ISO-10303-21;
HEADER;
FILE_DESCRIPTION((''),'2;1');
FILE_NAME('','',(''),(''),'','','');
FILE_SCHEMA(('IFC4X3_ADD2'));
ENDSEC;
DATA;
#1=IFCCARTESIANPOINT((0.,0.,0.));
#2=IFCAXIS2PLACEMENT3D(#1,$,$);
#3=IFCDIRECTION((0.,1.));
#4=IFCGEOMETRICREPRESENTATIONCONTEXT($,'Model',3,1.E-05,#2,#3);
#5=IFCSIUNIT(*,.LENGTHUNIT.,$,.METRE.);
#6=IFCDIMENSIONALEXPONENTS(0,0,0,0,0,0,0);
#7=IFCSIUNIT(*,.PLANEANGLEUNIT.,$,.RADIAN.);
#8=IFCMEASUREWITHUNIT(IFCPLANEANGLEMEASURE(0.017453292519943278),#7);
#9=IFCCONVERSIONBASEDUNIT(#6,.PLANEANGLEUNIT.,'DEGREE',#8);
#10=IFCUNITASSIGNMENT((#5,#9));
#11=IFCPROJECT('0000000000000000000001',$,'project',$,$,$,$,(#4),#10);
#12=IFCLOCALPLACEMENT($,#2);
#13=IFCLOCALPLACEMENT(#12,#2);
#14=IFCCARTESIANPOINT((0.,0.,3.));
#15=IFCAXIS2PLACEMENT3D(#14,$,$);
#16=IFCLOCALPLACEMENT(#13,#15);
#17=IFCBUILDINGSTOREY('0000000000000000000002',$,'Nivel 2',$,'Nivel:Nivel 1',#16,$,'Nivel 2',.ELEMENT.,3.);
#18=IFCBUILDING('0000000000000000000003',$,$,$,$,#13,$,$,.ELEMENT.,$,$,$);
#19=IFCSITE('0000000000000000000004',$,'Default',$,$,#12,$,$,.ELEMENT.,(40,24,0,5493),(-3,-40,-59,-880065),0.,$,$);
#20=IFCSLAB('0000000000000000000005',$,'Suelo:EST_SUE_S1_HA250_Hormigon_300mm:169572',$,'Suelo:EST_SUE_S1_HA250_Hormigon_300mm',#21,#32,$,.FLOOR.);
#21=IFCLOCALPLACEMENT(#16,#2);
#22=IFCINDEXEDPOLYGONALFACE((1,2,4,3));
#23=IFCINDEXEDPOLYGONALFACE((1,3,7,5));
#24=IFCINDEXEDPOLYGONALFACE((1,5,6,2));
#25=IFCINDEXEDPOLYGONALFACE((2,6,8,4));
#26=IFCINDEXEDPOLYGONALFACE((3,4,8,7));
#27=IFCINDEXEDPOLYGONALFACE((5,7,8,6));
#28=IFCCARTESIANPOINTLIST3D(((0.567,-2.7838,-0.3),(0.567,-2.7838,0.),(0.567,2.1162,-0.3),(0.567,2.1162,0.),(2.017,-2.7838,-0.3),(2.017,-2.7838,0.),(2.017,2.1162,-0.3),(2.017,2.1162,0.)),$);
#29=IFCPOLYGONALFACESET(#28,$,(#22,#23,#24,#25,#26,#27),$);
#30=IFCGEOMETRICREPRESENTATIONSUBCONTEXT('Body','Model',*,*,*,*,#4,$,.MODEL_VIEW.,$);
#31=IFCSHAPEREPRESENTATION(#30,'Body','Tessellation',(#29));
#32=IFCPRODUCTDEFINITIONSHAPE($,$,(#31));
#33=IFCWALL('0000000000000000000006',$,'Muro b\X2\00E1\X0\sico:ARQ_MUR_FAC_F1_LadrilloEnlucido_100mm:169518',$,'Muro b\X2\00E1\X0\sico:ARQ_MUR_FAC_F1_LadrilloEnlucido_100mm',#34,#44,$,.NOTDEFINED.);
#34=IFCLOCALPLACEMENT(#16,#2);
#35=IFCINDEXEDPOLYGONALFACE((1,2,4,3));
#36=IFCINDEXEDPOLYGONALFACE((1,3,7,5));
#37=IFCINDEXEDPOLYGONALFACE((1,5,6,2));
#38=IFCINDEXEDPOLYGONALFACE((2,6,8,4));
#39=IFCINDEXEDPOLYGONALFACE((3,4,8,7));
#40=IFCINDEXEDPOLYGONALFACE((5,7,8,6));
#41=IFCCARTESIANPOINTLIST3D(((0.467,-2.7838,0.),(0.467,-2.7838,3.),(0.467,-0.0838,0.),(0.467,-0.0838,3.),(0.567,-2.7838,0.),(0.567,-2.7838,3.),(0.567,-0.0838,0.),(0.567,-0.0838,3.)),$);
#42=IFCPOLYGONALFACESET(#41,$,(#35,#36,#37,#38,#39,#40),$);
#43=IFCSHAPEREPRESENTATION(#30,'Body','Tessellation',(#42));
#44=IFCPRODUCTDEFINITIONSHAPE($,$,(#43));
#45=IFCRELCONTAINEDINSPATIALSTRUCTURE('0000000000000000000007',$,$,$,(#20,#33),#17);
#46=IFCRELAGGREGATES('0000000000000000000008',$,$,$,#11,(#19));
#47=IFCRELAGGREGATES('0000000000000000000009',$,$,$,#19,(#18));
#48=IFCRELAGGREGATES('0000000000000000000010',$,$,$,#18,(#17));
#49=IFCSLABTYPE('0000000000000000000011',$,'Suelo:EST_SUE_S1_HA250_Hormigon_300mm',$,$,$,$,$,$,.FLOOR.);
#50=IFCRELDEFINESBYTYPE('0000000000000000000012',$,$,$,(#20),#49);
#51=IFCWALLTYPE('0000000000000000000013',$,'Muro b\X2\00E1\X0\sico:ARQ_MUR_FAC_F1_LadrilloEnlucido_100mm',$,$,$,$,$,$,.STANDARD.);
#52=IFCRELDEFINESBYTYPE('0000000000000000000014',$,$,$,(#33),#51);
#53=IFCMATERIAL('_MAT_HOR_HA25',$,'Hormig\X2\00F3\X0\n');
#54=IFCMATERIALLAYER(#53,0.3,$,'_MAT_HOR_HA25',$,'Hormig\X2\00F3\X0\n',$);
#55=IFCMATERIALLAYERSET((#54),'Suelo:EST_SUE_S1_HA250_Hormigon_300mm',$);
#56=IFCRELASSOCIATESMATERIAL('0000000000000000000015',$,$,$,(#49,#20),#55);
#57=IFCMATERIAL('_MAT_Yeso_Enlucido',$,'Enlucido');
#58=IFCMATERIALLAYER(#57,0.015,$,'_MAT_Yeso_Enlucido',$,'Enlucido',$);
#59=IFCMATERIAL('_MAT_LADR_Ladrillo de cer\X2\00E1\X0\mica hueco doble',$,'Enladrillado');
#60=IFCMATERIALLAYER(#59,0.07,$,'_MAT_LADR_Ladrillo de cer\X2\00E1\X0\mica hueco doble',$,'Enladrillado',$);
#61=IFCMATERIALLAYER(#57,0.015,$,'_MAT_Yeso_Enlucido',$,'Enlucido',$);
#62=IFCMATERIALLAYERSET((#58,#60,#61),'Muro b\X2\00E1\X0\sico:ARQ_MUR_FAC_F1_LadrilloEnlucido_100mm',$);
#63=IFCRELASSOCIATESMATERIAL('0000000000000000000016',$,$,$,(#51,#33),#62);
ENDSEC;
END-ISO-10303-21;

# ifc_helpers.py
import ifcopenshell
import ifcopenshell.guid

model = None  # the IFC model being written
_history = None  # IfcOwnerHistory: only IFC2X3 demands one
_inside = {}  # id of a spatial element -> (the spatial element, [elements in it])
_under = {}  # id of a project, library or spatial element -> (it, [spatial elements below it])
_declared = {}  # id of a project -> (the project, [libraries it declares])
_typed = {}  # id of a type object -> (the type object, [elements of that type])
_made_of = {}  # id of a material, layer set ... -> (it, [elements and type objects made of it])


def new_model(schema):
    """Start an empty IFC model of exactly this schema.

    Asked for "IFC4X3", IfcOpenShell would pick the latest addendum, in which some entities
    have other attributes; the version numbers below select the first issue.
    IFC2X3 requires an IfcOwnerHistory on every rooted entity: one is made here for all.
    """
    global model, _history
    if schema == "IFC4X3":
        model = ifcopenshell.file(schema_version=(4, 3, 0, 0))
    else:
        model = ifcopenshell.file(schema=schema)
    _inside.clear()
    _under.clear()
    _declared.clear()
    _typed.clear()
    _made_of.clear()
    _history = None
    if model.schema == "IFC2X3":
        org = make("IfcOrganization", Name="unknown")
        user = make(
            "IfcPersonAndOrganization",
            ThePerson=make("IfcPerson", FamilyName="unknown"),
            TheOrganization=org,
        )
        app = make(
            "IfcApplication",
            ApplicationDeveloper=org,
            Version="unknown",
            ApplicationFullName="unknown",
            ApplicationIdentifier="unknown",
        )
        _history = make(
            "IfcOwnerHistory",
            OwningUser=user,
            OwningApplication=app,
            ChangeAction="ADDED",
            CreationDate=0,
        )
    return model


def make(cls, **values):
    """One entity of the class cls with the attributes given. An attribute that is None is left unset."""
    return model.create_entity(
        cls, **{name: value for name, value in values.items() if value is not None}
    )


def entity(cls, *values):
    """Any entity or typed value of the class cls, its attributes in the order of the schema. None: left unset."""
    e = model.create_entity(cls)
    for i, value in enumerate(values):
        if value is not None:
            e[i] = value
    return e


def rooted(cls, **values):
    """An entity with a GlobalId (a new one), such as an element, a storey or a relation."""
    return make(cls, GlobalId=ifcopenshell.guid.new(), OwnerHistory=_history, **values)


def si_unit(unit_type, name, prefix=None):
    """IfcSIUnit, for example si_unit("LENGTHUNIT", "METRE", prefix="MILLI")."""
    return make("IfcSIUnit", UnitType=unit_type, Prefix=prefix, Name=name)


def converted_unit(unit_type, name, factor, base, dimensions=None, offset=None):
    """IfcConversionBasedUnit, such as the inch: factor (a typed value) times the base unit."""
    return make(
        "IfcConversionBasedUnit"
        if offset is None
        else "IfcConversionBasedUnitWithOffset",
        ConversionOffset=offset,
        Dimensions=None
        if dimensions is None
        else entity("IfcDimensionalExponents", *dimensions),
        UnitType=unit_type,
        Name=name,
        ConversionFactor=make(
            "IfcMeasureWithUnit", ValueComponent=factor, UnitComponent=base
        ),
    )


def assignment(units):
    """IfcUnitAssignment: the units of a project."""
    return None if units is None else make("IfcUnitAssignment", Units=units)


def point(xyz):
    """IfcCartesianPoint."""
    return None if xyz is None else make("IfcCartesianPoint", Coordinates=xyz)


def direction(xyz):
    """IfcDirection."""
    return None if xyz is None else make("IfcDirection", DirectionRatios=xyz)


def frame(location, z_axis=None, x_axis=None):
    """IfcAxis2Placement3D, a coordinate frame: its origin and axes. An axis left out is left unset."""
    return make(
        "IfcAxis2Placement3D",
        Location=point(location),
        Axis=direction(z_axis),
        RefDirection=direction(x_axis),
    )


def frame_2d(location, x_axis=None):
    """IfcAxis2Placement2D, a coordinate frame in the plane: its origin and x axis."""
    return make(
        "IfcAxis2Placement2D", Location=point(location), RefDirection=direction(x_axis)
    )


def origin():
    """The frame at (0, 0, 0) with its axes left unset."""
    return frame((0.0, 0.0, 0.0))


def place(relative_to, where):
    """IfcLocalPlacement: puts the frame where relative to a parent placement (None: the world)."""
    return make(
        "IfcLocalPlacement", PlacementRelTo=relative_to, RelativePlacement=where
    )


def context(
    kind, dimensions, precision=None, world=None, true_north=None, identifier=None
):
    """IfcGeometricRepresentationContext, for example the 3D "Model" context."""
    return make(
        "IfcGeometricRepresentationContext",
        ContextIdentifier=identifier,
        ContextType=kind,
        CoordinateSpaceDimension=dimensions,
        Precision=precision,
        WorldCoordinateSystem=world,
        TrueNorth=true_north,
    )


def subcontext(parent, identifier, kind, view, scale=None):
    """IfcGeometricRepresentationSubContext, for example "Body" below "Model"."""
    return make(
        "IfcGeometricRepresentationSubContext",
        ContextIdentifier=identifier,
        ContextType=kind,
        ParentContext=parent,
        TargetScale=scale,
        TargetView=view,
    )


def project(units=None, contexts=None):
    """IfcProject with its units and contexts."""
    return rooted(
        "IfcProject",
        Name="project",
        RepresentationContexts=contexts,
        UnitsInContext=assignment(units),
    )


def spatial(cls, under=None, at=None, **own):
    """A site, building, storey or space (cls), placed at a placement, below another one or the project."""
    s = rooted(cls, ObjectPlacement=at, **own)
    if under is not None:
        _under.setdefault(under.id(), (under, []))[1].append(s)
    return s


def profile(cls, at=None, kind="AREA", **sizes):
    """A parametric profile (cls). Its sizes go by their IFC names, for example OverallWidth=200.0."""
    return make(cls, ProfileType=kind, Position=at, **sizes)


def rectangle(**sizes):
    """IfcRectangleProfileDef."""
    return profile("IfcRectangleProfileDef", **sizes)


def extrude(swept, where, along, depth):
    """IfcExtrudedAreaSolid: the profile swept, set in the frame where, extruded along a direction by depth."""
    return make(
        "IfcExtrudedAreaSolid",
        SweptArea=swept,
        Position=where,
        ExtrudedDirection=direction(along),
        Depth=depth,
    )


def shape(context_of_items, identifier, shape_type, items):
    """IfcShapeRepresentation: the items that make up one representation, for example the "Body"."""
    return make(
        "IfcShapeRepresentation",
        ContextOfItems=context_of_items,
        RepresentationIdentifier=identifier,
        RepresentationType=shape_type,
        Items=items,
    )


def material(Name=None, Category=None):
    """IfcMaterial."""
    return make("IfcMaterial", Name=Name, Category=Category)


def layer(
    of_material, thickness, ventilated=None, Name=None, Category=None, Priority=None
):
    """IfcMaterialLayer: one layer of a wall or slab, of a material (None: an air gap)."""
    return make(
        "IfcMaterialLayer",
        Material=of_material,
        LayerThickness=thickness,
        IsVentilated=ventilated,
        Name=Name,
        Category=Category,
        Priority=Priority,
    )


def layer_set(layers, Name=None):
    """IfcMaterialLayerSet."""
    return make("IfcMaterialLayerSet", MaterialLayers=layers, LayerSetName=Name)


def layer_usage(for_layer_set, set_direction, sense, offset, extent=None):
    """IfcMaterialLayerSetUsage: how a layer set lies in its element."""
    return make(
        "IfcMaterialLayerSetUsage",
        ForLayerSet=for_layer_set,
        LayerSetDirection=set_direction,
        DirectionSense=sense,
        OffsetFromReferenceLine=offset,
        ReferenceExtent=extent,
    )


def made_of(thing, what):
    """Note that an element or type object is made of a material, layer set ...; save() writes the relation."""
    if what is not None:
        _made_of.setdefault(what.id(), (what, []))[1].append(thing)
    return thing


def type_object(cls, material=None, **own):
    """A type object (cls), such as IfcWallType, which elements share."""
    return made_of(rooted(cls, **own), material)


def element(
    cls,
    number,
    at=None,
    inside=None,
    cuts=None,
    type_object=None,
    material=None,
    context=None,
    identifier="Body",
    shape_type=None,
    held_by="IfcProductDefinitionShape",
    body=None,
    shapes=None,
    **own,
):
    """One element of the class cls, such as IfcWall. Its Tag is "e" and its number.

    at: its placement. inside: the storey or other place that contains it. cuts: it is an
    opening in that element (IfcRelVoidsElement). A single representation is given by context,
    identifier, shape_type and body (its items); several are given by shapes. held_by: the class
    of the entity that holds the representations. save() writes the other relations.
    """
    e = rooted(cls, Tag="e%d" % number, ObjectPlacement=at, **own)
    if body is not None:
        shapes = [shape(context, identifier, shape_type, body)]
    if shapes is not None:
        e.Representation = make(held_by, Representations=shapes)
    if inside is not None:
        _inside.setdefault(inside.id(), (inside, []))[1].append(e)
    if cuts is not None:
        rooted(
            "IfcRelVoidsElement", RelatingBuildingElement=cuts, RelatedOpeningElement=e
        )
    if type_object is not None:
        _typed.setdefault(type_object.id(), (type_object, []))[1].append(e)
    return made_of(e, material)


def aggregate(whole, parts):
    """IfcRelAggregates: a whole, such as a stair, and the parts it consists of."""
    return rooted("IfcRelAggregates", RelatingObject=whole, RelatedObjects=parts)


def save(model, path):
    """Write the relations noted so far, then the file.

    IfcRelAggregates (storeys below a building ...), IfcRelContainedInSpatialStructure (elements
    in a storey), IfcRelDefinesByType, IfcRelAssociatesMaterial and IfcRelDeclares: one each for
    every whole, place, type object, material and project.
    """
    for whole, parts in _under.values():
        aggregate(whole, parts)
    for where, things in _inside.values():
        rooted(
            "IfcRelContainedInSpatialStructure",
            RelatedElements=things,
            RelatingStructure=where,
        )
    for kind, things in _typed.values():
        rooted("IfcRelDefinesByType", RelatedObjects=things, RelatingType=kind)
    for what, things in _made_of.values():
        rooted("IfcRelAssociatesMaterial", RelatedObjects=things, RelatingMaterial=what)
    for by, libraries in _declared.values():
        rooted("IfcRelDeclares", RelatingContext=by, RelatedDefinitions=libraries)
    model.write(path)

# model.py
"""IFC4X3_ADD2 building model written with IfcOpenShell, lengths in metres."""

from ifc_helpers import new_model, entity, si_unit, converted_unit, direction, frame, frame_2d, origin, place, context, subcontext, project, spatial, rectangle, extrude, material, layer, layer_set, layer_usage, type_object, element, save


model = new_model("IFC4X3_ADD2")

# Units and contexts
model_context = context("Model", 3, precision=1e-05, world=origin(), true_north=direction((0.0, 1.0)))
body_context = subcontext(model_context, "Body", "Model", "MODEL_VIEW")
ifc_project = project(units=[si_unit("LENGTHUNIT", "METRE"), converted_unit("PLANEANGLEUNIT", "DEGREE", entity("IfcPlaneAngleMeasure", 0.017453292519943278), si_unit("PLANEANGLEUNIT", "RADIAN"), dimensions=[0, 0, 0, 0, 0, 0, 0])], contexts=[model_context])

# Site, building, storey
site_placement = place(None, origin())
site = spatial("IfcSite", under=ifc_project, at=site_placement, Name="Default", CompositionType="ELEMENT", RefLatitude=(40, 24, 0, 5493), RefLongitude=(-3, -40, -59, -880065), RefElevation=0.0)
building_placement = place(site_placement, origin())
building = spatial("IfcBuilding", under=site, at=building_placement, CompositionType="ELEMENT")
storey_placement = place(building_placement, frame((0.0, 0.0, 3.0)))
storey = spatial("IfcBuildingStorey", under=building, at=storey_placement, Name="Nivel 2", ObjectType="Nivel:Nivel 1", LongName="Nivel 2", CompositionType="ELEMENT", Elevation=3.0)

# Slab
ifc_material_1 = material(Name="_MAT_HOR_HA25", Category="Hormigón")
ifc_layer_1 = layer(ifc_material_1, 0.3, Name="_MAT_HOR_HA25", Category="Hormigón")
ifc_layer_set_1 = layer_set([ifc_layer_1], Name="Suelo:EST_SUE_S1_HA250_Hormigon_300mm")
ifc_layer_usage = layer_usage(ifc_layer_set_1, "AXIS3", "POSITIVE", 0.0)
slab_type = type_object("IfcSlabType", Name="Suelo:EST_SUE_S1_HA250_Hormigon_300mm", PredefinedType="FLOOR", material=ifc_layer_set_1)
slab_placement = place(storey_placement, origin())
element("IfcSlab", 1, at=slab_placement, inside=storey, type_object=slab_type, material=ifc_layer_usage, Name="Suelo:EST_SUE_S1_HA250_Hormigon_300mm:169572", ObjectType="Suelo:EST_SUE_S1_HA250_Hormigon_300mm", PredefinedType="FLOOR", context=body_context, shape_type="SweptSolid", body=[
    extrude(rectangle(XDim=4.9, YDim=1.45, at=frame_2d((0.0, 0.0), x_axis=(1.0, 0.0))), frame((1.292, -0.3338, 0.0), z_axis=(0.0, 0.0, -1.0), x_axis=(0.0, 1.0, 0.0)), (0.0, 0.0, 1.0), 0.3),
])

# Wall
ifc_material_2 = material(Name="_MAT_Yeso_Enlucido", Category="Enlucido")
ifc_layer_2 = layer(ifc_material_2, 0.015, Name="_MAT_Yeso_Enlucido", Category="Enlucido")
ifc_material_3 = material(Name="_MAT_LADR_Ladrillo de cerámica hueco doble", Category="Enladrillado")
ifc_layer_3 = layer(ifc_material_3, 0.07, Name="_MAT_LADR_Ladrillo de cerámica hueco doble", Category="Enladrillado")
ifc_layer_4 = layer(ifc_material_2, 0.015, Name="_MAT_Yeso_Enlucido", Category="Enlucido")
ifc_layer_set_2 = layer_set([ifc_layer_2, ifc_layer_3, ifc_layer_4], Name="Muro básico:ARQ_MUR_FAC_F1_LadrilloEnlucido_100mm")
wall_type = type_object("IfcWallType", Name="Muro básico:ARQ_MUR_FAC_F1_LadrilloEnlucido_100mm", PredefinedType="STANDARD", material=ifc_layer_set_2)
wall_placement = place(storey_placement, frame((0.517, -2.7838, 0.0), z_axis=(0.0, 0.0, 1.0), x_axis=(0.0, 1.0, 0.0)))
element("IfcWall", 2, at=wall_placement, inside=storey, type_object=wall_type, material=ifc_layer_set_2, Name="Muro básico:ARQ_MUR_FAC_F1_LadrilloEnlucido_100mm:169518", ObjectType="Muro básico:ARQ_MUR_FAC_F1_LadrilloEnlucido_100mm", PredefinedType="NOTDEFINED", context=body_context, shape_type="SweptSolid", body=[
    extrude(rectangle(XDim=2.7, YDim=0.1, at=frame_2d((1.35, 0.0), x_axis=(-1.0, 0.0))), origin(), (0.0, 0.0, 1.0), 3.0),
])

save(model, "model.ifc")
